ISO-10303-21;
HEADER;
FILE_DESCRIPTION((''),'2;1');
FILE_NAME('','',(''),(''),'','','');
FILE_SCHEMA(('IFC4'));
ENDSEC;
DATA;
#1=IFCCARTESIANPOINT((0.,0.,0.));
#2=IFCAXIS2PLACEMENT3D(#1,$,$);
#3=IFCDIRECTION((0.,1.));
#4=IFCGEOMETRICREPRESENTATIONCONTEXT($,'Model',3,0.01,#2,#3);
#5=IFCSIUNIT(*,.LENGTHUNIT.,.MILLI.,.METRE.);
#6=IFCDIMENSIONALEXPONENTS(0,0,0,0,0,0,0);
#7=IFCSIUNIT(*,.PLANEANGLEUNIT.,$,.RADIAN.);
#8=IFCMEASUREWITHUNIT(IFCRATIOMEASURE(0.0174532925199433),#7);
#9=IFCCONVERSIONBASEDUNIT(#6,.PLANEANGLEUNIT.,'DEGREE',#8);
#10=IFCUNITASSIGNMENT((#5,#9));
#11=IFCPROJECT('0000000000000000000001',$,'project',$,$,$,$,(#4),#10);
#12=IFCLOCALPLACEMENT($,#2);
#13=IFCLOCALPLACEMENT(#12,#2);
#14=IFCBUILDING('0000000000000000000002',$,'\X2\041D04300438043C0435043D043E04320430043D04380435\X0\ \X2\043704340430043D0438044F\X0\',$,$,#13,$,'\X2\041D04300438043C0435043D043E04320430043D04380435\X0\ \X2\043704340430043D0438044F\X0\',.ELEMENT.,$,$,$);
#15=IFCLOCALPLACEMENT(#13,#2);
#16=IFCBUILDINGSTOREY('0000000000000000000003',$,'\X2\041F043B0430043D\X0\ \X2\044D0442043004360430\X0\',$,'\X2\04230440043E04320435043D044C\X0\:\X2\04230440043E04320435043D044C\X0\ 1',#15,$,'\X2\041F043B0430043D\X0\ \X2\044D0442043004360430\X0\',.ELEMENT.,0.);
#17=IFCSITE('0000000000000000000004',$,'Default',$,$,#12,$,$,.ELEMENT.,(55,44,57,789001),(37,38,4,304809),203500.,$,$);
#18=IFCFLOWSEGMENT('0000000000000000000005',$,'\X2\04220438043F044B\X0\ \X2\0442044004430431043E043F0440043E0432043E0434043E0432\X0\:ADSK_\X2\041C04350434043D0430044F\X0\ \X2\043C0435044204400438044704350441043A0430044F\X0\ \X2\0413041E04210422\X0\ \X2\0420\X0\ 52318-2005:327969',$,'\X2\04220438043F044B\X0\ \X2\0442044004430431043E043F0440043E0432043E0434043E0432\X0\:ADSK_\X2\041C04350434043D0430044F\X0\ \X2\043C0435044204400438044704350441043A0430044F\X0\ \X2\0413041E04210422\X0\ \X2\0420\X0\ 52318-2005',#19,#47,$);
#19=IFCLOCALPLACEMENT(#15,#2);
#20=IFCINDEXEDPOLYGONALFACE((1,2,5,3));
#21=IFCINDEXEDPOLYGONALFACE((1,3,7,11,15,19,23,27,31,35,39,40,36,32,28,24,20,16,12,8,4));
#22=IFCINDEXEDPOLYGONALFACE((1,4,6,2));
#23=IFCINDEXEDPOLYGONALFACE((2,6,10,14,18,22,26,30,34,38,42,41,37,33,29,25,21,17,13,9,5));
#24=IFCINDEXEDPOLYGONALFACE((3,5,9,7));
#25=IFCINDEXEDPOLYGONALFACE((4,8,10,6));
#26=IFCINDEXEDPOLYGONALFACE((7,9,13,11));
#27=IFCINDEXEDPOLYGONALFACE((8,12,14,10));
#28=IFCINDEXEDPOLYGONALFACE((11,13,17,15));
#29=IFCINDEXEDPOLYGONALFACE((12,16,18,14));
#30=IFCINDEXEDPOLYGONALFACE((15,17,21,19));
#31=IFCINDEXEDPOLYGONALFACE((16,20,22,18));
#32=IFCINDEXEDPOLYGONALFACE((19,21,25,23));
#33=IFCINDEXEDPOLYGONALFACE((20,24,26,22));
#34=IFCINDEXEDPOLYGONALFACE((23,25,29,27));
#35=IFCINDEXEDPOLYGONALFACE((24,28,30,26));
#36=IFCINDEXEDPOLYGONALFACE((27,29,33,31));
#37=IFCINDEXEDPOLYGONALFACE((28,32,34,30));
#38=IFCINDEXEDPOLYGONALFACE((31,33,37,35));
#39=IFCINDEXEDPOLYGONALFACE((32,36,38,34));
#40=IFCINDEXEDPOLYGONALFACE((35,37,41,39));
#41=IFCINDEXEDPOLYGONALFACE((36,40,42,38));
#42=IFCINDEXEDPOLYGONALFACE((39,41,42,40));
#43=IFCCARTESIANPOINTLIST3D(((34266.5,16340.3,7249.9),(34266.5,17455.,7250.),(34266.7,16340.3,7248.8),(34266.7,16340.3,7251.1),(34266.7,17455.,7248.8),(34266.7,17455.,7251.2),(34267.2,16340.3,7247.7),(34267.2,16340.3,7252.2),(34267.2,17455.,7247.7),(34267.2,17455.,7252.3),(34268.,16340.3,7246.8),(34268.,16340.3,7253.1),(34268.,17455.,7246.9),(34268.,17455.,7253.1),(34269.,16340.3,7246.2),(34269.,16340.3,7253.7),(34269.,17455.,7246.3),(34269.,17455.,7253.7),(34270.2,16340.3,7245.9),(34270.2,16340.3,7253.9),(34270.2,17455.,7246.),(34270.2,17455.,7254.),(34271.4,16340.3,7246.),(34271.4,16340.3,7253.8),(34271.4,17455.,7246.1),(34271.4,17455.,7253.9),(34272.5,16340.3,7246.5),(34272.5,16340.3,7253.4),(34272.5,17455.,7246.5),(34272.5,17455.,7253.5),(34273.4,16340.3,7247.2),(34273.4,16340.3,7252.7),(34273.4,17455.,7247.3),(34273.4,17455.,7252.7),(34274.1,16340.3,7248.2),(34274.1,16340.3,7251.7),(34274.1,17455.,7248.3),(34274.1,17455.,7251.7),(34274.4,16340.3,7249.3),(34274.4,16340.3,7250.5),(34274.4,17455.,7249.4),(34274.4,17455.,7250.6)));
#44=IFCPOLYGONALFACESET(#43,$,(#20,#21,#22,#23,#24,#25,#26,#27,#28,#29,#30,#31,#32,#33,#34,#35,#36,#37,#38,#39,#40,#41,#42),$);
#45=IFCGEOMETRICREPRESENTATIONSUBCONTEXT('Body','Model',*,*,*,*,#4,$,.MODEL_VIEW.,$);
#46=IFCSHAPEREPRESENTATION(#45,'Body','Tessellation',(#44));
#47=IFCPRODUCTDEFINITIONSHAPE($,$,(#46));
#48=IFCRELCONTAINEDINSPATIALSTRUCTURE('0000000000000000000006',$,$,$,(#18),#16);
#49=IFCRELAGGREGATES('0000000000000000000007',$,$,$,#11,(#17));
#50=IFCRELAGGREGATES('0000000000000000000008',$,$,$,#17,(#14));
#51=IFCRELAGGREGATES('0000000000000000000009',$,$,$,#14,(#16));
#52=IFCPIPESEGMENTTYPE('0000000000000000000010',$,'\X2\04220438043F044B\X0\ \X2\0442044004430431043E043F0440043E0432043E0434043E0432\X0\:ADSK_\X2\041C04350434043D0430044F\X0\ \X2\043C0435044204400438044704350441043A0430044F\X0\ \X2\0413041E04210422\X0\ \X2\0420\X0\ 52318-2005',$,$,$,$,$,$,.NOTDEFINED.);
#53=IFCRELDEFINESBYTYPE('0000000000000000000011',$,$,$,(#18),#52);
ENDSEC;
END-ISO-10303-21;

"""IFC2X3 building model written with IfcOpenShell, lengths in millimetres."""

from ifc_helpers import new_model, entity, si_unit, converted_unit, direction, frame, origin, origin_2d_with_axis, place, context, subcontext, project, spatial, circle, extrude, type_object, element, save


model = new_model("IFC2X3")

# Units and contexts
model_context = context("Model", 3, precision=0.01, world=origin(), true_north=direction((0.0, 1.0)))
body_context = subcontext(model_context, "Body", "Model", "MODEL_VIEW")
ifc_project = project(units=[si_unit("LENGTHUNIT", "METRE", prefix="MILLI"), converted_unit("PLANEANGLEUNIT", "DEGREE", entity("IfcRatioMeasure", 0.0174532925199433), si_unit("PLANEANGLEUNIT", "RADIAN"), dimensions=[0, 0, 0, 0, 0, 0, 0])], contexts=[model_context])

# Site, building, storey
site_placement = place(None, frame((0.0, 0.0, 0.0)))
site = spatial("IfcSite", under=ifc_project, at=site_placement, Name="Default", CompositionType="ELEMENT", RefLatitude=(55, 44, 57, 789001), RefLongitude=(37, 38, 4, 304809), RefElevation=203500.0)
building_placement = place(site_placement, origin())
building = spatial("IfcBuilding", under=site, at=building_placement, Name="Наименование здания", LongName="Наименование здания", CompositionType="ELEMENT")
storey_placement = place(building_placement, origin())
storey = spatial("IfcBuildingStorey", under=building, at=storey_placement, Name="План этажа", ObjectType="Уровень:Уровень 1", LongName="План этажа", CompositionType="ELEMENT", Elevation=0.0)

# Flow segment
pipe_segment_type = type_object("IfcPipeSegmentType", Name="Типы трубопроводов:ADSK_Медная метрическая ГОСТ Р 52318-2005", PredefinedType="NOTDEFINED")
flow_segment_1_placement = place(storey_placement, frame((34264.9, 16340.3, 7244.3)))
element("IfcFlowSegment", 1, at=flow_segment_1_placement, inside=storey, type_object=pipe_segment_type, Name="Типы трубопроводов:ADSK_Медная метрическая ГОСТ Р 52318-2005:327969", ObjectType="Типы трубопроводов:ADSK_Медная метрическая ГОСТ Р 52318-2005", context=body_context, shape_type="SweptSolid", body=[
    extrude(circle(Radius=4.0, at=origin_2d_with_axis()), frame((5.6, 0.0, 5.6), z_axis=(0.0, 1.0, 0.000062), x_axis=(-1.0, 0.0, 0.0)), (0.0, 0.0, 1.0), 1114.7),
])

save(model, "model.ifc")
